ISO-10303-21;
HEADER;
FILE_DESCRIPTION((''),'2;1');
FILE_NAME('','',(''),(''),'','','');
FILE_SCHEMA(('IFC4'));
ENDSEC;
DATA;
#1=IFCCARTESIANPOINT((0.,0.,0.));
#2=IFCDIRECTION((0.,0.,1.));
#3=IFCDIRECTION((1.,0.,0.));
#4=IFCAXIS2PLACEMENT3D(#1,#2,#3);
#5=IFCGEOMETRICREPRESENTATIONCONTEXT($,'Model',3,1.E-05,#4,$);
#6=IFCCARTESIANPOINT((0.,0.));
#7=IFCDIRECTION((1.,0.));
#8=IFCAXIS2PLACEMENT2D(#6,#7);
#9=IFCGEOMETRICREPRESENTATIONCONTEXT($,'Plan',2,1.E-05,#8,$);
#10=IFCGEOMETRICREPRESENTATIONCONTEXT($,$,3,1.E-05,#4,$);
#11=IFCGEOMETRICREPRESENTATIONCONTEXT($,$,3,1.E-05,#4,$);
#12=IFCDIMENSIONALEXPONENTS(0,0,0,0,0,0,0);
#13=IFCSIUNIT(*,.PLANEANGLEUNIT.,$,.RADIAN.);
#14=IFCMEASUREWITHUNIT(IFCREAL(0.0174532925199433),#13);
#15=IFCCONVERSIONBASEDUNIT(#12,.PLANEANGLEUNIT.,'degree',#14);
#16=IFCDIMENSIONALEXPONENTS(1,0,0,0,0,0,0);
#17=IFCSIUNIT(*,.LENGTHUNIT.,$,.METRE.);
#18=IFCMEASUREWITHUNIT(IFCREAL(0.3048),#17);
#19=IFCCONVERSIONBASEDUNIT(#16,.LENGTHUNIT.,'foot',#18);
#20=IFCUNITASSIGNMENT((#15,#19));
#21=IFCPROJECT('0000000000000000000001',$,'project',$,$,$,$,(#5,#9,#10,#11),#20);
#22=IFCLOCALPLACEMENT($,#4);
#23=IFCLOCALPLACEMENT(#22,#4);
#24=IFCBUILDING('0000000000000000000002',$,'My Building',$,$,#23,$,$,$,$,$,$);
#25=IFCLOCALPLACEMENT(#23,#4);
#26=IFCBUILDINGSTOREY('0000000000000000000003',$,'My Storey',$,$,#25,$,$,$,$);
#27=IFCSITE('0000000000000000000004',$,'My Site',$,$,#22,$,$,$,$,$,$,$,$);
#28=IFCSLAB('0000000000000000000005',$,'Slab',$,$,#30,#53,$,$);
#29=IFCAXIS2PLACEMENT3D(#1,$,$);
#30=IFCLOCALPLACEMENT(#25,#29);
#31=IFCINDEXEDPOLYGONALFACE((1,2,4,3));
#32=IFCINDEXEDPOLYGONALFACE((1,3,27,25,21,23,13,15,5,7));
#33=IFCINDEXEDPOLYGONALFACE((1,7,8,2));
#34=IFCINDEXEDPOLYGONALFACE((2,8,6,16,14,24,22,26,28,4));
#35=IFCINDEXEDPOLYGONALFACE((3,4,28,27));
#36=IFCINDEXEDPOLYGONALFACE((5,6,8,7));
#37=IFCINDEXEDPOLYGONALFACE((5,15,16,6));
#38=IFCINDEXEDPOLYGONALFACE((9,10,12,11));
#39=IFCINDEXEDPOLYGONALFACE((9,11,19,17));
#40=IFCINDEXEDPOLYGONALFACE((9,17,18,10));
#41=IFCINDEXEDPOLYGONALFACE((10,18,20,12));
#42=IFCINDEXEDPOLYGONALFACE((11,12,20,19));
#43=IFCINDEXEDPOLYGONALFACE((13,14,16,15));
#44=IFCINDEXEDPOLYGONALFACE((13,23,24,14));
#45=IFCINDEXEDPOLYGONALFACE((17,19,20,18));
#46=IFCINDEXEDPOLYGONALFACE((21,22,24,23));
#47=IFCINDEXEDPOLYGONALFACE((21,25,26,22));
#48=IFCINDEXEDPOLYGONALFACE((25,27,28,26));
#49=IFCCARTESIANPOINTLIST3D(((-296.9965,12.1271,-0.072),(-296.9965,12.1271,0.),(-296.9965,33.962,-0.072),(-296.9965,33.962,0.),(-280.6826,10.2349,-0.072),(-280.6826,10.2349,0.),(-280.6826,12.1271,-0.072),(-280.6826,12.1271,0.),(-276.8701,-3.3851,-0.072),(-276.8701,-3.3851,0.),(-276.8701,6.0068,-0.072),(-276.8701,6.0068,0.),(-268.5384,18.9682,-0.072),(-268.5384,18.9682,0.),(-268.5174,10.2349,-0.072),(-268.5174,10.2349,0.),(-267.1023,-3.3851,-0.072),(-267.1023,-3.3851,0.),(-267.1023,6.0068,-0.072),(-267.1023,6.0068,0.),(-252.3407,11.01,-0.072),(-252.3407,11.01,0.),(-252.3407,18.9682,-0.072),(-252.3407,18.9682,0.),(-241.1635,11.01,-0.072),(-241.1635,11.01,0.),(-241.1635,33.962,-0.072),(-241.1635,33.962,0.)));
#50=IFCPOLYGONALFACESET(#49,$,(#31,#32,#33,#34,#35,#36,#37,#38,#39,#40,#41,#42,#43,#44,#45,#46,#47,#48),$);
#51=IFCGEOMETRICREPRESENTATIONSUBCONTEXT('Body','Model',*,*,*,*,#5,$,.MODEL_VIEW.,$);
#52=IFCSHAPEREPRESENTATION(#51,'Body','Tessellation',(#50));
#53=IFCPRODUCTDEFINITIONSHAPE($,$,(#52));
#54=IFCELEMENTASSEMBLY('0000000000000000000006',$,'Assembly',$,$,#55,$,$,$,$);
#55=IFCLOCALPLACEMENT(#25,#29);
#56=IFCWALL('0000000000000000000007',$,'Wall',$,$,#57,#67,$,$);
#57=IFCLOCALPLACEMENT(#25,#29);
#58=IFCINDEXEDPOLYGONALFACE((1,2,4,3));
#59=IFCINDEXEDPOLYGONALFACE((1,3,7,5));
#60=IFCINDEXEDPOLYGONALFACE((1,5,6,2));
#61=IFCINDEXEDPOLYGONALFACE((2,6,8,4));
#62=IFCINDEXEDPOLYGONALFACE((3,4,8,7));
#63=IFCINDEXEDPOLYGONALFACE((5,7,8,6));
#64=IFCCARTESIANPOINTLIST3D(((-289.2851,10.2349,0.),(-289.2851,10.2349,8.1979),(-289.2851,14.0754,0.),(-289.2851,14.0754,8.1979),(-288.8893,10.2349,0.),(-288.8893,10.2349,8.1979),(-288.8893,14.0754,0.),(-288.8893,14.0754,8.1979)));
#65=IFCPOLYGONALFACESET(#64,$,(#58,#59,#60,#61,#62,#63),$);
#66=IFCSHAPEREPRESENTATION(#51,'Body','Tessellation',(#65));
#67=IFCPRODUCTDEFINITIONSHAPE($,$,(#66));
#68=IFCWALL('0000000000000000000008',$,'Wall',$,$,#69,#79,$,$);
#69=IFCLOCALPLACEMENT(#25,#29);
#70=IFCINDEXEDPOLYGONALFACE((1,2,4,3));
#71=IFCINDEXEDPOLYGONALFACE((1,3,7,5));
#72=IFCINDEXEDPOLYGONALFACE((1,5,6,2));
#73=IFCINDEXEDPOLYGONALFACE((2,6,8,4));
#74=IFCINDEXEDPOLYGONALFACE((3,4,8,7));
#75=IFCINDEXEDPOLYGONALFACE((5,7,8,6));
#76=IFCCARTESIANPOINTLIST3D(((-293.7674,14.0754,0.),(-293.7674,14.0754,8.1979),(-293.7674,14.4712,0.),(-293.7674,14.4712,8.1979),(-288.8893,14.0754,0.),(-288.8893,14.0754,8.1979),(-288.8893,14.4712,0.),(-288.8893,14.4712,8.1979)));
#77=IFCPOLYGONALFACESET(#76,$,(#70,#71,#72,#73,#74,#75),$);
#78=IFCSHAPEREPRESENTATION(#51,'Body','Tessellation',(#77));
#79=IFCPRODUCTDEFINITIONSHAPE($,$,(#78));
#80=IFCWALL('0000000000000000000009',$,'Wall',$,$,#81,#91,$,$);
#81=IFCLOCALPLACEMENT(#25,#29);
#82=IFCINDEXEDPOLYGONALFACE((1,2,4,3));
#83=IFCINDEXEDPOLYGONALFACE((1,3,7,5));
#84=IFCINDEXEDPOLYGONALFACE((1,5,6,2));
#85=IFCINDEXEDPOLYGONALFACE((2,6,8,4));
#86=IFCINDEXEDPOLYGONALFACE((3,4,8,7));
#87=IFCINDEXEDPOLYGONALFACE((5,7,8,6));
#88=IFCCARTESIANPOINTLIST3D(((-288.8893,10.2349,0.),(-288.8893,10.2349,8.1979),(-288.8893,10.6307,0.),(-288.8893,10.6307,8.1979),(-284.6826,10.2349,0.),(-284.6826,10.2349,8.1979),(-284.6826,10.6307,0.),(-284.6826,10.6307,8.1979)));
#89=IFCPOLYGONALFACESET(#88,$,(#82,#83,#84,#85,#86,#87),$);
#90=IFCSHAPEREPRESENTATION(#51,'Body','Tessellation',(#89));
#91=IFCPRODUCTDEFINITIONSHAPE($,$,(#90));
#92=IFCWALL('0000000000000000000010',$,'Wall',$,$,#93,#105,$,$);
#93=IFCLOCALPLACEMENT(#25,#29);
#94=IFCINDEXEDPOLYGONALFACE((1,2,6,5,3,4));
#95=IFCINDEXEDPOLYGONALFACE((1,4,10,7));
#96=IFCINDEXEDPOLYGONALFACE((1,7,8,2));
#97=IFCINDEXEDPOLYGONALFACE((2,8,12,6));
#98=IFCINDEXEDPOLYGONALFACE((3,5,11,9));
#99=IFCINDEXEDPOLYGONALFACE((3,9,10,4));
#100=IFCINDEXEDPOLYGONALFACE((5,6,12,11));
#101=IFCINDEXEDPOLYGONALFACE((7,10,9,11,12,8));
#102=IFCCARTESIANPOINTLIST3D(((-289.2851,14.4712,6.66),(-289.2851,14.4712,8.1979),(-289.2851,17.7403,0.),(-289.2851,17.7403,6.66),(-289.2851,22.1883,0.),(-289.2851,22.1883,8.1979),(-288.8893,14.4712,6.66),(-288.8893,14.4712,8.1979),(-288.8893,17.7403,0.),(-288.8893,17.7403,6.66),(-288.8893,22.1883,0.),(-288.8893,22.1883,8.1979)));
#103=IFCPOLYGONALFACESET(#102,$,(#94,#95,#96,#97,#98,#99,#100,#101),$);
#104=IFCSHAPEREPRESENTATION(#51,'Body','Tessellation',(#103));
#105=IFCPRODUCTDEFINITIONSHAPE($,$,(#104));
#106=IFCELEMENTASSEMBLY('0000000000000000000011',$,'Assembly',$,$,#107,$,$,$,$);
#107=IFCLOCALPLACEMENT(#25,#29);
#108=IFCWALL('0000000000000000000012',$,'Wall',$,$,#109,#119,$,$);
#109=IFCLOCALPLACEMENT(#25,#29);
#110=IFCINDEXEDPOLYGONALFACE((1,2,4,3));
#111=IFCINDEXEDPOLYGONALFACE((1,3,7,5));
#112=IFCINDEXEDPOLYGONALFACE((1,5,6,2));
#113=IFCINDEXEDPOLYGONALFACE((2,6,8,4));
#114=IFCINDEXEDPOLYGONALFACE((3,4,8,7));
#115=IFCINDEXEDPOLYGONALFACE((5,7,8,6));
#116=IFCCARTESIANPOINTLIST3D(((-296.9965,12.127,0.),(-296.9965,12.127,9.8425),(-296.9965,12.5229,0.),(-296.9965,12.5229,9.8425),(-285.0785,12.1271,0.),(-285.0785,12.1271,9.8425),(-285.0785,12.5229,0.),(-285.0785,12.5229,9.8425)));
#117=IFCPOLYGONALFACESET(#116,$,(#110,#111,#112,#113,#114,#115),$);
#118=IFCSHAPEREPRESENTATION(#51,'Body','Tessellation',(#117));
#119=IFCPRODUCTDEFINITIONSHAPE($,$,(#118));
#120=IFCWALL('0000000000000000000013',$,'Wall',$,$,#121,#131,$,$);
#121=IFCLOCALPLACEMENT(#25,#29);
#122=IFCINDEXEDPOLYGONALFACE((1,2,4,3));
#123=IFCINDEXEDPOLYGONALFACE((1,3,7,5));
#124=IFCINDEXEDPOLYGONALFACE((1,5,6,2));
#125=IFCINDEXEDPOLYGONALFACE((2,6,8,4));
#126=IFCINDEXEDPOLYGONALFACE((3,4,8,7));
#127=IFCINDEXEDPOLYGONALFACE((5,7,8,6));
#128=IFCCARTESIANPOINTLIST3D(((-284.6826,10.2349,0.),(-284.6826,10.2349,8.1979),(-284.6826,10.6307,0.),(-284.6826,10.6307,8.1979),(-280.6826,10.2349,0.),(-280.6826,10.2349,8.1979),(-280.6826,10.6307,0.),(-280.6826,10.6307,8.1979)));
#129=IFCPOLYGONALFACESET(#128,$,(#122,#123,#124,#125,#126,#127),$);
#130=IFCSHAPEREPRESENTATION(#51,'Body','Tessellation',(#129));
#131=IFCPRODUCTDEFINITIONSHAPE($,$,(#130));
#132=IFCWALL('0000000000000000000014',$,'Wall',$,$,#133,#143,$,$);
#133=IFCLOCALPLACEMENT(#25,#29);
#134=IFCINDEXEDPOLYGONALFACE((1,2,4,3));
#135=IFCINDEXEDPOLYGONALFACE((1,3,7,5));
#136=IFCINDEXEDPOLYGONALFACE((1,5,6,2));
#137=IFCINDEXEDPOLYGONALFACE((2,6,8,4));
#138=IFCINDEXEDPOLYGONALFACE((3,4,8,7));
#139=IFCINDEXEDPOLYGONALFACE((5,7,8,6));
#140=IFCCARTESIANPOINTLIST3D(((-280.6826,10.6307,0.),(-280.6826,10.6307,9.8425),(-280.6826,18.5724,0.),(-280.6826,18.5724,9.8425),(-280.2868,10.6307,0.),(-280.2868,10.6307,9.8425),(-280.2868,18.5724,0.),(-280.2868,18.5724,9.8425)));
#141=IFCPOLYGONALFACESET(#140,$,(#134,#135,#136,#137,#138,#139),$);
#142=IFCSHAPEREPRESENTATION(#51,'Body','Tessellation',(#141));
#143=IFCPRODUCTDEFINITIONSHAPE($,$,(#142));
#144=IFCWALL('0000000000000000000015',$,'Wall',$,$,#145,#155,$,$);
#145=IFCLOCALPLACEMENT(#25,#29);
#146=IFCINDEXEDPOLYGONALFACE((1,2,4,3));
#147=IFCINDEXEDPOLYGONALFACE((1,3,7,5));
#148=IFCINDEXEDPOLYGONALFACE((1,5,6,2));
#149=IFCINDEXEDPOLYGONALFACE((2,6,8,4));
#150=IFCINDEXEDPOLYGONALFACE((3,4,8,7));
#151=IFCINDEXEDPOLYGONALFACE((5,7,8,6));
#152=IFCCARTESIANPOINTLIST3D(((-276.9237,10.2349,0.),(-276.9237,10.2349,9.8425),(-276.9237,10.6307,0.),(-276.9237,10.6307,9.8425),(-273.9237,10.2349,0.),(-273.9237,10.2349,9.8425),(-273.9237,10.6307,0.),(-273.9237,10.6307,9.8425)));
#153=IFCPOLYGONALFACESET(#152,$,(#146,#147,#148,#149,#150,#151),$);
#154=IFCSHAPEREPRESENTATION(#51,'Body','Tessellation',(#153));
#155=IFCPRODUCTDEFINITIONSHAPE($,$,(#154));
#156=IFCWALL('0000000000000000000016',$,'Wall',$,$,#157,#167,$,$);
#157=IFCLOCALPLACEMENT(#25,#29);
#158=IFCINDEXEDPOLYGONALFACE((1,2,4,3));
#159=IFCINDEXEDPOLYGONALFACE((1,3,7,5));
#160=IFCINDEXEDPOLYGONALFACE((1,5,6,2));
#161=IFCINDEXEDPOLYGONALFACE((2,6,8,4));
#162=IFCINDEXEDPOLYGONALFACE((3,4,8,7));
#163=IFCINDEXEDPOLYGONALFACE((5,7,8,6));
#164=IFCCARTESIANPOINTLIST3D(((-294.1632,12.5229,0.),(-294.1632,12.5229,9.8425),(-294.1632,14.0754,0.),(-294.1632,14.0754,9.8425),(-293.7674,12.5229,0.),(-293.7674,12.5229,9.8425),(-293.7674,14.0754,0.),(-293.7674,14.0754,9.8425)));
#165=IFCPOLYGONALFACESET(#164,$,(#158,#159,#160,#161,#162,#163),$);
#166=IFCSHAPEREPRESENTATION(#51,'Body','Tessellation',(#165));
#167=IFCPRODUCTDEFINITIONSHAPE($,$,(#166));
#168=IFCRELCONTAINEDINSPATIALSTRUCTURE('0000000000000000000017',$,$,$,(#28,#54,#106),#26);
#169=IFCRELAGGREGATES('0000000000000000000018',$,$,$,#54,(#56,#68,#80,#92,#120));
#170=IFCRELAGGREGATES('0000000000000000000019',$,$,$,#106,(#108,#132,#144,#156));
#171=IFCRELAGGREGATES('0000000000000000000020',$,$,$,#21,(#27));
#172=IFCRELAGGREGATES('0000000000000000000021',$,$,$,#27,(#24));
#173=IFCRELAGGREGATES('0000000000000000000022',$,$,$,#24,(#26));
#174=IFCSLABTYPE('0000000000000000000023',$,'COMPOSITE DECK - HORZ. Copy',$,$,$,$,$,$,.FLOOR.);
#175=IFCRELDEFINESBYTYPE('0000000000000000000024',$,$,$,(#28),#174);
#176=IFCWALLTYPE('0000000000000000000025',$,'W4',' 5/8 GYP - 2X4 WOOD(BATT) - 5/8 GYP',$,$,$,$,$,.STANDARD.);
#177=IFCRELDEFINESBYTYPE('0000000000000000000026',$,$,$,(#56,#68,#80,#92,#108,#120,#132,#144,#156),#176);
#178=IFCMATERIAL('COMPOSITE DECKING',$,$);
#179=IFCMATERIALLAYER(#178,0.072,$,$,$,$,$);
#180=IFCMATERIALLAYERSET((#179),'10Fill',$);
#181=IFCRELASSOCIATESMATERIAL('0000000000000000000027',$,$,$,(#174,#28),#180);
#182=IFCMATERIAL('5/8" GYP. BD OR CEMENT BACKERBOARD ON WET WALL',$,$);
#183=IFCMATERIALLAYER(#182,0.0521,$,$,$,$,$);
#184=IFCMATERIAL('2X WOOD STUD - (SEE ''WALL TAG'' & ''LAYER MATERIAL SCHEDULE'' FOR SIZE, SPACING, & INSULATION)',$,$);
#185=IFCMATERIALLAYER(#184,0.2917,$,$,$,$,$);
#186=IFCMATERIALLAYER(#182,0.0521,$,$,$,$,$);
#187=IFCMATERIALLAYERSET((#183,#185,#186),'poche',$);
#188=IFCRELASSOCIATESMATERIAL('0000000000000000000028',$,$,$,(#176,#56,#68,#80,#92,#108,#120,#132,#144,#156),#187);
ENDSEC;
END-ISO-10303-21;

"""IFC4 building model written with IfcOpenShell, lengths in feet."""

from ifc_helpers import new_model, entity, si_unit, converted_unit, frame, origin_with_axes, origin_2d_with_axis, place, context, subcontext, project, spatial, line, indexed_curve, outline, extrude, material, layer, layer_set, layer_usage, type_object, element, aggregate, save


model = new_model("IFC4")

# Units and contexts
model_context = context("Model", 3, precision=1e-05, world=origin_with_axes())
plan_context = context("Plan", 2, precision=1e-05, world=origin_2d_with_axis())
context_of_model_1 = context(None, 3, precision=1e-05, world=origin_with_axes())
context_of_model_2 = context(None, 3, precision=1e-05, world=origin_with_axes())
body_context_1 = subcontext(model_context, "Body", "Model", "MODEL_VIEW")
ifc_project = project(units=[converted_unit("PLANEANGLEUNIT", "degree", entity("IfcReal", 0.0174532925199433), si_unit("PLANEANGLEUNIT", "RADIAN"), dimensions=[0, 0, 0, 0, 0, 0, 0]), converted_unit("LENGTHUNIT", "foot", entity("IfcReal", 0.3048), si_unit("LENGTHUNIT", "METRE"), dimensions=[1, 0, 0, 0, 0, 0, 0])], contexts=[model_context, plan_context, context_of_model_1, context_of_model_2])

# Site, building, storey
site_placement = place(None, origin_with_axes())
site = spatial("IfcSite", under=ifc_project, at=site_placement, Name="My Site")
building_placement = place(site_placement, origin_with_axes())
building = spatial("IfcBuilding", under=site, at=building_placement, Name="My Building")
storey_placement = place(building_placement, origin_with_axes())
storey = spatial("IfcBuildingStorey", under=building, at=storey_placement, Name="My Storey")

# Slab
ifc_material_1 = material(Name="COMPOSITE DECKING")
ifc_layer_1 = layer(ifc_material_1, 0.072)
ifc_layer_set_1 = layer_set([ifc_layer_1], Name="10Fill")
ifc_layer_usage_1 = layer_usage(ifc_layer_set_1, "AXIS3", "POSITIVE", 0.0)
slab_type = type_object("IfcSlabType", Name="COMPOSITE DECK - HORZ. Copy", PredefinedType="FLOOR", material=ifc_layer_set_1)
slab_placement = place(storey_placement, frame((-296.9965, 12.1271, -0.072), z_axis=(0.0, 0.0, 1.0), x_axis=(1.0, 0.0, 0.0)))
element("IfcSlab", 1, at=slab_placement, inside=storey, type_object=slab_type, material=ifc_layer_usage_1, Name="Slab", context=body_context_1, shape_type="SweptSolid", body=[
    extrude(outline(indexed_curve([(16.3139, -1.8922), (28.4792, -1.8922), (28.4582, 6.8412), (44.6559, 6.8412), (44.6558, -1.117), (55.833, -1.117), (55.833, 21.8349), (0.0, 21.8349), (0.0, 0.0), (16.3139, 0.0), (29.8943, -15.5121), (20.1265, -15.5121), (20.1265, -6.1202), (29.8943, -6.1202)], segments=[line(5, 4), line(4, 3), line(3, 2), line(2, 1), line(1, 10), line(10, 9), line(9, 8), line(8, 7), line(7, 6), line(6, 5)], self_intersect=False), holes=[indexed_curve([(16.3139, -1.8922), (28.4792, -1.8922), (28.4582, 6.8412), (44.6559, 6.8412), (44.6558, -1.117), (55.833, -1.117), (55.833, 21.8349), (0.0, 21.8349), (0.0, 0.0), (16.3139, 0.0), (29.8943, -15.5121), (20.1265, -15.5121), (20.1265, -6.1202), (29.8943, -6.1202)], segments=[line(13, 12), line(12, 11), line(11, 14), line(14, 13)], self_intersect=False)]), None, (0.0, 0.0, 1.0), 0.072),
])

# Element assembly, walls, openings
assembly_1_placement = place(storey_placement, origin_with_axes())
assembly_1 = element("IfcElementAssembly", 2, at=assembly_1_placement, inside=storey, Name="Assembly")
ifc_material_2 = material(Name="5/8\" GYP. BD OR CEMENT BACKERBOARD ON WET WALL")
ifc_layer_2 = layer(ifc_material_2, 0.0521)
ifc_material_3 = material(Name="2X WOOD STUD - (SEE 'WALL TAG' & 'LAYER MATERIAL SCHEDULE' FOR SIZE, SPACING, & INSULATION)")
ifc_layer_3 = layer(ifc_material_3, 0.2917)
ifc_layer_4 = layer(ifc_material_2, 0.0521)
ifc_layer_set_2 = layer_set([ifc_layer_2, ifc_layer_3, ifc_layer_4], Name="poche")
ifc_layer_usage_2 = layer_usage(ifc_layer_set_2, "AXIS2", "POSITIVE", 0.0)
wall_type_1 = type_object("IfcWallType", Name="W4", Description=" 5/8 GYP - 2X4 WOOD(BATT) - 5/8 GYP", PredefinedType="STANDARD", material=ifc_layer_set_2)
wall_1_placement = place(assembly_1_placement, frame((-288.8893, 10.2349, 0.0), z_axis=(0.0, 0.0, 1.0), x_axis=(0.0, 1.0, 0.0)))
wall_1 = element("IfcWall", 3, at=wall_1_placement, type_object=wall_type_1, material=ifc_layer_usage_2, Name="Wall", context=body_context_1, shape_type="SweptSolid", body=[
    extrude(outline(indexed_curve([(0.0, 0.0), (0.0, 0.3958), (3.8405, 0.3958), (3.8405, 0.0), (0.0, 0.0)], self_intersect=False)), origin_with_axes(), (0.0, 0.0, 1.0), 8.1979),
])
ifc_layer_usage_3 = layer_usage(ifc_layer_set_2, "AXIS2", "POSITIVE", 0.0)
wall_2_placement = place(assembly_1_placement, frame((-288.8893, 14.4712, 0.0), z_axis=(0.0, 0.0, 1.0), x_axis=(-1.0, 0.0, 0.0)))
wall_2 = element("IfcWall", 4, at=wall_2_placement, type_object=wall_type_1, material=ifc_layer_usage_3, Name="Wall", context=body_context_1, shape_type="SweptSolid", body=[
    extrude(outline(indexed_curve([(0.0, 0.0), (0.0, 0.3958), (4.8781, 0.3958), (4.8781, 0.0), (0.0, 0.0)], self_intersect=False)), origin_with_axes(), (0.0, 0.0, 1.0), 8.1979),
])
ifc_layer_usage_4 = layer_usage(ifc_layer_set_2, "AXIS2", "POSITIVE", 0.0)
wall_3_placement = place(assembly_1_placement, frame((-288.8893, 10.2349, 0.0), z_axis=(0.0, 0.0, 1.0), x_axis=(1.0, 0.0, 0.0)))
wall_3 = element("IfcWall", 5, at=wall_3_placement, type_object=wall_type_1, material=ifc_layer_usage_4, Name="Wall", context=body_context_1, shape_type="SweptSolid", body=[
    extrude(outline(indexed_curve([(0.0, 0.0), (0.0, 0.3958), (4.2066, 0.3958), (4.2066, 0.0), (0.0, 0.0)], self_intersect=False)), origin_with_axes(), (0.0, 0.0, 1.0), 8.1979),
])
ifc_layer_usage_5 = layer_usage(ifc_layer_set_2, "AXIS2", "POSITIVE", 0.0)
wall_4_placement = place(assembly_1_placement, frame((-288.8893, 14.4712, 0.0), z_axis=(0.0, 0.0, 1.0), x_axis=(0.0, 1.0, 0.0)))
wall_4 = element("IfcWall", 6, at=wall_4_placement, type_object=wall_type_1, material=ifc_layer_usage_5, Name="Wall", context=body_context_1, shape_type="SweptSolid", body=[
    extrude(outline(indexed_curve([(0.0, 0.0), (0.0, 0.3958), (7.717, 0.3958), (7.717, 0.0), (0.0, 0.0)], self_intersect=False)), origin_with_axes(), (0.0, 0.0, 1.0), 8.1979),
])
opening_1_placement = place(wall_4_placement, frame((1.6345, 0.816, 3.33), z_axis=(0.0, -1.0, 0.0), x_axis=(0.0, 0.0, -1.0)))
element("IfcOpeningElement", 7, at=opening_1_placement, cuts=wall_4, context=body_context_1, shape_type="SweptSolid", body=[
    extrude(outline(indexed_curve([(-3.33, -1.6345), (3.33, -1.6345), (3.33, 1.6345), (-3.33, 1.6345)], segments=[line(4, 1), line(1, 2), line(2, 3), line(3, 4)], self_intersect=False)), frame((0.0, 0.0, 0.0), z_axis=(0.0, 0.0, -1.0), x_axis=(1.0, 0.0, 0.0)), (0.0, 0.0, -1.0), 1.317),
])
opening_2_placement = place(wall_4_placement, frame((1.6345, 5.0564, 3.33), z_axis=(0.0, -1.0, 0.0), x_axis=(0.0, 0.0, -1.0)))
element("IfcOpeningElement", 8, at=opening_2_placement, cuts=wall_4, context=body_context_1, shape_type="SweptSolid", body=[
    extrude(outline(indexed_curve([(-3.33, -1.6345), (3.33, -1.6345), (3.33, 1.6345), (-3.33, 1.6345)], segments=[line(4, 1), line(1, 2), line(2, 3), line(3, 4)], self_intersect=False)), frame((0.0, 0.0, 0.0), z_axis=(0.0, 0.0, -1.0), x_axis=(1.0, 0.0, 0.0)), (0.0, 0.0, -1.0), 1.317),
])

# Element assembly, wall
assembly_2_placement = place(storey_placement, origin_with_axes())
assembly_2 = element("IfcElementAssembly", 9, at=assembly_2_placement, inside=storey, Name="Assembly")
ifc_layer_usage_6 = layer_usage(ifc_layer_set_2, "AXIS2", "POSITIVE", 0.0)
wall_5_placement = place(assembly_2_placement, frame((-285.0785, 12.5229, 0.0), z_axis=(0.0, 0.0, 1.0), x_axis=(-1.0, 0.0, 0.0)))
wall_5 = element("IfcWall", 10, at=wall_5_placement, type_object=wall_type_1, material=ifc_layer_usage_6, Name="Wall", context=body_context_1, shape_type="SweptSolid", body=[
    extrude(outline(indexed_curve([(0.0, 0.0), (0.0, 0.3958), (11.9181, 0.3958), (11.9181, 0.0), (0.0, 0.0)], self_intersect=False)), origin_with_axes(), (0.0, 0.0, 1.0), 9.8425),
])

# Wall
ifc_layer_usage_7 = layer_usage(ifc_layer_set_2, "AXIS2", "POSITIVE", 0.0)
wall_6_placement = place(assembly_1_placement, frame((-284.6826, 10.2349, 0.0), z_axis=(0.0, 0.0, 1.0), x_axis=(1.0, 0.0, 0.0)))
wall_6 = element("IfcWall", 11, at=wall_6_placement, type_object=wall_type_1, material=ifc_layer_usage_7, Name="Wall", context=body_context_1, shape_type="SweptSolid", body=[
    extrude(outline(indexed_curve([(0.0, 0.0), (0.0, 0.3958), (4.0, 0.3958), (4.0, 0.0), (0.0, 0.0)], self_intersect=False)), origin_with_axes(), (0.0, 0.0, 1.0), 8.1979),
])
aggregate(assembly_1, [wall_1, wall_2, wall_3, wall_4, wall_6])

# Wall
ifc_layer_usage_8 = layer_usage(ifc_layer_set_2, "AXIS2", "POSITIVE", 0.0)
wall_7_placement = place(assembly_2_placement, frame((-280.2868, 10.6307, 0.0), z_axis=(0.0, 0.0, 1.0), x_axis=(0.0, 1.0, 0.0)))
wall_7 = element("IfcWall", 12, at=wall_7_placement, type_object=wall_type_1, material=ifc_layer_usage_8, Name="Wall", context=body_context_1, shape_type="SweptSolid", body=[
    extrude(outline(indexed_curve([(0.0, 0.0), (0.0, 0.3958), (7.9417, 0.3958), (7.9417, 0.0), (0.0, 0.0)], self_intersect=False)), origin_with_axes(), (0.0, 0.0, 1.0), 9.8425),
])

# Wall
ifc_layer_usage_9 = layer_usage(ifc_layer_set_2, "AXIS2", "POSITIVE", 0.0)
wall_8_placement = place(assembly_2_placement, frame((-273.9237, 10.6307, 0.0), z_axis=(0.0, 0.0, 1.0), x_axis=(-1.0, 0.0, 0.0)))
wall_8 = element("IfcWall", 13, at=wall_8_placement, type_object=wall_type_1, material=ifc_layer_usage_9, Name="Wall", context=body_context_1, shape_type="SweptSolid", body=[
    extrude(outline(indexed_curve([(0.0, 0.0), (0.0, 0.3958), (3.0, 0.3958), (3.0, 0.0), (0.0, 0.0)], self_intersect=False)), origin_with_axes(), (0.0, 0.0, 1.0), 9.8425),
])

# Wall
ifc_layer_usage_10 = layer_usage(ifc_layer_set_2, "AXIS2", "POSITIVE", 0.0)
wall_9_placement = place(assembly_2_placement, frame((-293.7674, 12.5229, 0.0), z_axis=(0.0, 0.0, 1.0), x_axis=(0.0, 1.0, 0.0)))
wall_9 = element("IfcWall", 14, at=wall_9_placement, type_object=wall_type_1, material=ifc_layer_usage_10, Name="Wall", context=body_context_1, shape_type="SweptSolid", body=[
    extrude(outline(indexed_curve([(0.0, 0.0), (0.0, 0.3958), (1.5525, 0.3958), (1.5525, 0.0), (0.0, 0.0)], self_intersect=False)), origin_with_axes(), (0.0, 0.0, 1.0), 9.8425),
])

aggregate(assembly_2, [wall_5, wall_7, wall_8, wall_9])

save(model, "model.ifc")
